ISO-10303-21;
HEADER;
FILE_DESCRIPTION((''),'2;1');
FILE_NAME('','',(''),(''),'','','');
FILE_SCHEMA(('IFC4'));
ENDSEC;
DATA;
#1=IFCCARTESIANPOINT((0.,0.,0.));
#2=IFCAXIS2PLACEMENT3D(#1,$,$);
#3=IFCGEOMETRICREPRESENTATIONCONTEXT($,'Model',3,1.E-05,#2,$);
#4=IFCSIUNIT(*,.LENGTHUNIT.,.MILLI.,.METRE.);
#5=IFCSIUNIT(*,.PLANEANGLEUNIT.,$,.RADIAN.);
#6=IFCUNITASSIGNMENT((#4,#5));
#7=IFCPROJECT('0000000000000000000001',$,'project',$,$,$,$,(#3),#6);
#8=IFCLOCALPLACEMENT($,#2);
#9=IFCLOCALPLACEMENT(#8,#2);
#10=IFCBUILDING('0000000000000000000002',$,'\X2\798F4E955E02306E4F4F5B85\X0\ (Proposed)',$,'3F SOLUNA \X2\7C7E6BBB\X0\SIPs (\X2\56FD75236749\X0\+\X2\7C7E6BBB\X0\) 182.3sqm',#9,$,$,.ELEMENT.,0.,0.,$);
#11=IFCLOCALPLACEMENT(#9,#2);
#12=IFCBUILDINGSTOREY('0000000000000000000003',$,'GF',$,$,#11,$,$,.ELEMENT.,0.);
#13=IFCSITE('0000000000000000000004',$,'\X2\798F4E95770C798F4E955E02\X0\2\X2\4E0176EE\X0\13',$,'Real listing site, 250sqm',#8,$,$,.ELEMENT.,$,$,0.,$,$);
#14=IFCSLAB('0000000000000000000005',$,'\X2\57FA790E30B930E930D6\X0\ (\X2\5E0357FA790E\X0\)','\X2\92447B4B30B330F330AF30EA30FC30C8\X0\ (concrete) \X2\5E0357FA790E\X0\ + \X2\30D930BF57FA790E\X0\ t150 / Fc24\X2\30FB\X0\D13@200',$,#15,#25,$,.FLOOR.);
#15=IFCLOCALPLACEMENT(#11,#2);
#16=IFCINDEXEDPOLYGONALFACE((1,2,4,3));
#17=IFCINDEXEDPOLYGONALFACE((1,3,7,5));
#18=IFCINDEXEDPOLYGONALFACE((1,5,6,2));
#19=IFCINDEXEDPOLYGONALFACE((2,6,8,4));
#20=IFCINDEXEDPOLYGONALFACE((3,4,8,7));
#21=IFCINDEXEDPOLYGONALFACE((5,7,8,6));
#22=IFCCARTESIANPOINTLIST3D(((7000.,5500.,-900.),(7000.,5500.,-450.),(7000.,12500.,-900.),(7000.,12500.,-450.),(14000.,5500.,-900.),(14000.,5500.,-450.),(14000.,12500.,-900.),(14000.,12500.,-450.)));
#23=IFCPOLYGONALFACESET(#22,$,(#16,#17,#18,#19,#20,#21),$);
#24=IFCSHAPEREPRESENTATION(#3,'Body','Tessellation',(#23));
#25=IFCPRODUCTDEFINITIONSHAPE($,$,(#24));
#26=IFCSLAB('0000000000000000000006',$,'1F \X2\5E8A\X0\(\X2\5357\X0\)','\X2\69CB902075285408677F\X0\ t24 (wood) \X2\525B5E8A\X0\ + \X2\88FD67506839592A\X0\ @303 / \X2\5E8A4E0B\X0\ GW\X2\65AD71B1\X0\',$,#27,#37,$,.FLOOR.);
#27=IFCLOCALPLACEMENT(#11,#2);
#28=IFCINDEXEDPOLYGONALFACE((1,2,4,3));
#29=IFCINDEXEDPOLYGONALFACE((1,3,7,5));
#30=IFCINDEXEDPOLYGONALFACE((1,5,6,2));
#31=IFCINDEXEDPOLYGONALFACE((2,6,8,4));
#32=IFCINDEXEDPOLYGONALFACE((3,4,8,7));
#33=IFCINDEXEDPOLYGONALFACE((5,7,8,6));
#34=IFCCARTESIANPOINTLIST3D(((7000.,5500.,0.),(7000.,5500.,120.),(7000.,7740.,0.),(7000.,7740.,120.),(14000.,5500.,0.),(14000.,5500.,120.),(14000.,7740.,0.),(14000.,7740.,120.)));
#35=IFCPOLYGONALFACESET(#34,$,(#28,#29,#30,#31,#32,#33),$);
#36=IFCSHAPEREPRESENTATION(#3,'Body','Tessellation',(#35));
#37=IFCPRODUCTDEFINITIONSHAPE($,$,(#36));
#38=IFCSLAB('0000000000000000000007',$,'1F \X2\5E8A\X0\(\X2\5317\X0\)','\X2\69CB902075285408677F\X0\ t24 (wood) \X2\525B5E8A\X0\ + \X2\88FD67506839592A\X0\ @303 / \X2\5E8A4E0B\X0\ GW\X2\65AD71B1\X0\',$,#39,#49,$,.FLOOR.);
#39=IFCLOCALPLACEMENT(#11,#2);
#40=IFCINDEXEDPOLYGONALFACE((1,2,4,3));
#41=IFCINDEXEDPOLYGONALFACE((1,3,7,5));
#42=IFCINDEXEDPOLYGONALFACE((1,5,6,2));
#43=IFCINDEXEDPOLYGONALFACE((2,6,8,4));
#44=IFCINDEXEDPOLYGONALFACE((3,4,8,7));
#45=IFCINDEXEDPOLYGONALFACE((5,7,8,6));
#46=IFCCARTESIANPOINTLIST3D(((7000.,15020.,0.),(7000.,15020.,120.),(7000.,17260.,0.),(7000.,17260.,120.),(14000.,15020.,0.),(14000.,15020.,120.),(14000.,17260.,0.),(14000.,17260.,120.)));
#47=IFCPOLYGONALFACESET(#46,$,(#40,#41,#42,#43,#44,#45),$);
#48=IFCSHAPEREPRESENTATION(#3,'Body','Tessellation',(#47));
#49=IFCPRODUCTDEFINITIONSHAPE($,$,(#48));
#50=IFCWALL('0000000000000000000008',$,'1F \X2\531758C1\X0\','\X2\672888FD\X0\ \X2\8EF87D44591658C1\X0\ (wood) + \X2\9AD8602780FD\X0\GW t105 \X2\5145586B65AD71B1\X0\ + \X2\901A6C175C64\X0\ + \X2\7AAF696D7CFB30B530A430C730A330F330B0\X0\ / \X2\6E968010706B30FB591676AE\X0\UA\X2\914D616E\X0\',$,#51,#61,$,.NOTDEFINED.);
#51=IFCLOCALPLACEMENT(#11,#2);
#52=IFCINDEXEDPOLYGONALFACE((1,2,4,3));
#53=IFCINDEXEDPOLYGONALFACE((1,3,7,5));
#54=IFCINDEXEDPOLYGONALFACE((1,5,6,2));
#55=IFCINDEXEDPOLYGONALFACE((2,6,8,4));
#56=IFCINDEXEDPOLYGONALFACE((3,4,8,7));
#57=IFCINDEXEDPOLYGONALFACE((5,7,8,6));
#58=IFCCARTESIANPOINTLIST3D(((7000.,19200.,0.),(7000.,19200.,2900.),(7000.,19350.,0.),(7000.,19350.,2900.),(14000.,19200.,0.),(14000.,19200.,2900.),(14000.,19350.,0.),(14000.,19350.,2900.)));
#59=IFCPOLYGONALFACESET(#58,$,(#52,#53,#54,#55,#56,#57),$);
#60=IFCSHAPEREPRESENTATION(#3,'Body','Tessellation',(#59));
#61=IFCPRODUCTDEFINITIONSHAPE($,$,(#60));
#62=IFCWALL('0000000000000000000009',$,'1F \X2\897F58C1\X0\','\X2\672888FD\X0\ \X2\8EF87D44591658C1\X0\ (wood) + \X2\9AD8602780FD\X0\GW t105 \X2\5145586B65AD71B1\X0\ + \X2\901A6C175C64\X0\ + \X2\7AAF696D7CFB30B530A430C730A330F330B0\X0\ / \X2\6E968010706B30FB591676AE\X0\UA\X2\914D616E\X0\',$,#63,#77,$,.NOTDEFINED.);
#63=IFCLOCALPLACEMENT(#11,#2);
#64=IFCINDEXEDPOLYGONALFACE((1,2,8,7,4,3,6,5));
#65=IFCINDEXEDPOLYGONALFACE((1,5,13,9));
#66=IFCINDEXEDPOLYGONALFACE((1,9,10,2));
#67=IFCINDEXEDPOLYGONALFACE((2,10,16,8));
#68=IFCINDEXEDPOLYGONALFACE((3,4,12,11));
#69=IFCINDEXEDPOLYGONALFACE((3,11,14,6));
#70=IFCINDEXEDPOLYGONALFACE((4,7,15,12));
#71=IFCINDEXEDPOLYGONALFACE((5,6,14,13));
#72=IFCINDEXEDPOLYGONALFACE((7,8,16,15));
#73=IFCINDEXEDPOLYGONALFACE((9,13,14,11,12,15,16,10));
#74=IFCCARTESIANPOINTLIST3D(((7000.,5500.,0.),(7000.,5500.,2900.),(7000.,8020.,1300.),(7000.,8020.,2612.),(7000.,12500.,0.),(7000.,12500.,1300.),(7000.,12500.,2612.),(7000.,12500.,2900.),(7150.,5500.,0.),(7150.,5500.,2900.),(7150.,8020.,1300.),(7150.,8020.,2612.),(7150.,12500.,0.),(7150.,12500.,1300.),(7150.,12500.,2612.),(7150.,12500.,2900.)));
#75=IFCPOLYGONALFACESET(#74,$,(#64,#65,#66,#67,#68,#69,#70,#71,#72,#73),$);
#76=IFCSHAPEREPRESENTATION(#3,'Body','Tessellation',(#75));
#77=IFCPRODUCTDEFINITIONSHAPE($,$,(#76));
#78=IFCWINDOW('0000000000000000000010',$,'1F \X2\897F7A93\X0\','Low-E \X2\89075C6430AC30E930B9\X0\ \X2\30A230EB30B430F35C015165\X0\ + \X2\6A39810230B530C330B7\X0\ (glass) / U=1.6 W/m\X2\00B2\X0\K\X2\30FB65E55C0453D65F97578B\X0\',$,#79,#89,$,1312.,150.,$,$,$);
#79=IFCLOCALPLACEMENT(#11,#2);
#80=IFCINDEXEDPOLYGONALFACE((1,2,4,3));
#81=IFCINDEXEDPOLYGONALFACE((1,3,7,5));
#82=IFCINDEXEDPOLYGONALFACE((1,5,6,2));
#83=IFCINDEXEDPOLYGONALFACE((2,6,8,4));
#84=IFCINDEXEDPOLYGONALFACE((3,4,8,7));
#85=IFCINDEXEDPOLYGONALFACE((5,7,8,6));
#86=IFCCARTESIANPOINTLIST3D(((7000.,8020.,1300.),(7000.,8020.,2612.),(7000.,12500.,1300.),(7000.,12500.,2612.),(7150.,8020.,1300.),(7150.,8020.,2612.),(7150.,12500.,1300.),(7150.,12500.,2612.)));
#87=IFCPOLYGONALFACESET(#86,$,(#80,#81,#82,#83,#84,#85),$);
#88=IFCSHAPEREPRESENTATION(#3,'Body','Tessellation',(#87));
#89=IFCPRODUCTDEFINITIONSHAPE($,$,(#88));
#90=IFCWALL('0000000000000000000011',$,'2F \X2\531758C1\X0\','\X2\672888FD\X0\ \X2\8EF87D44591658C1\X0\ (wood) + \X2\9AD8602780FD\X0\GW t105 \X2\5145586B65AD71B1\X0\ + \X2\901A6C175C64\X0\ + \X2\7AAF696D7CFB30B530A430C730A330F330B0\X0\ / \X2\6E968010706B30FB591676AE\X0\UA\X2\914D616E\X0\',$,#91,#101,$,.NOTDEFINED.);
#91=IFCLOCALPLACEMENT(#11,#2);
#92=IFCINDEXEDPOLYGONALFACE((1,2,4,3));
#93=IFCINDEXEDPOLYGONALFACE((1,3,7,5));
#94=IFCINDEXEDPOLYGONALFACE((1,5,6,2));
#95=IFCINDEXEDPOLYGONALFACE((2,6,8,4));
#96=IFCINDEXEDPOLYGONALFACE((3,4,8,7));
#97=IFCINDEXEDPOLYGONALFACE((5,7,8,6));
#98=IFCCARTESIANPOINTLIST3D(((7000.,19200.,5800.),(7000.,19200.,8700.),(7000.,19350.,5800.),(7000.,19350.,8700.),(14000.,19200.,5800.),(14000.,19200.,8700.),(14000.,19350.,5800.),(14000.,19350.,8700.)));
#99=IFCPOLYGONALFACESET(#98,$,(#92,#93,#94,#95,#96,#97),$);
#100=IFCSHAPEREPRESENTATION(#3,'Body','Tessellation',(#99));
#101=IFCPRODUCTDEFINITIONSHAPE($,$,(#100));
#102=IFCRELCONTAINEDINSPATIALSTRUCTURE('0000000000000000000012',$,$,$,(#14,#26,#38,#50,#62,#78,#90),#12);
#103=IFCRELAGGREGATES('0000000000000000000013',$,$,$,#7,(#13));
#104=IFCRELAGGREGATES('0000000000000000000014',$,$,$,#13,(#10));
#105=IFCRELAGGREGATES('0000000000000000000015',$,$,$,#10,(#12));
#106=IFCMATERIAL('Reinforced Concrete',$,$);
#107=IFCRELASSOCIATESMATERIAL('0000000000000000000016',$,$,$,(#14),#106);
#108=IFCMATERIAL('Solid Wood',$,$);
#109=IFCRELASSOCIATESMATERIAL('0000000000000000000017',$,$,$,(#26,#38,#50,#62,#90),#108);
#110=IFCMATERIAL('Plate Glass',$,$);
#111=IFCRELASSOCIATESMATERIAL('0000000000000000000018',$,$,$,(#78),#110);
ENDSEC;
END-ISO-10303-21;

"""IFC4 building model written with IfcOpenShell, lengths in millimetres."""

from ifc_helpers import new_model, si_unit, frame, frame_2d, origin, place, context, project, spatial, rectangle, extrude, material, element, fill, save


model = new_model("IFC4")

# Units and contexts
model_context = context("Model", 3, precision=1e-05, world=origin())
ifc_project = project(units=[si_unit("LENGTHUNIT", "METRE", prefix="MILLI"), si_unit("PLANEANGLEUNIT", "RADIAN")], contexts=[model_context])

# Site, building, storey
site_placement = place(None, origin())
site = spatial("IfcSite", under=ifc_project, at=site_placement, Name="福井県福井市2丁目13", ObjectType="Real listing site, 250sqm", CompositionType="ELEMENT", RefElevation=0.0)
building_placement = place(site_placement, origin())
building = spatial("IfcBuilding", under=site, at=building_placement, Name="福井市の住宅 (Proposed)", ObjectType="3F SOLUNA 籾殻SIPs (国産杉+籾殻) 182.3sqm", CompositionType="ELEMENT", ElevationOfRefHeight=0.0, ElevationOfTerrain=0.0)
storey_placement = place(building_placement, origin())
storey = spatial("IfcBuildingStorey", under=building, at=storey_placement, Name="GF", CompositionType="ELEMENT", Elevation=0.0)

# Slabs
ifc_material_1 = material(Name="Reinforced Concrete")
slab_1_placement = place(storey_placement, frame((3500.0, 2750.0, -450.0)))
element("IfcSlab", 1, at=slab_1_placement, inside=storey, material=ifc_material_1, Name="基礎スラブ (布基礎)", Description="鉄筋コンクリート (concrete) 布基礎 + ベタ基礎 t150 / Fc24・D13@200", PredefinedType="FLOOR", context=model_context, shape_type="SweptSolid", body=[
    extrude(rectangle(XDim=7000.0, YDim=7000.0, at=frame_2d((3500.0, 3500.0))), frame((3500.0, 2750.0, -450.0)), (0.0, 0.0, 1.0), 450.0),
])
ifc_material_2 = material(Name="Solid Wood")
slab_2_placement = place(storey_placement, frame((3500.0, 2750.0, 0.0)))
element("IfcSlab", 2, at=slab_2_placement, inside=storey, material=ifc_material_2, Name="1F 床(南)", Description="構造用合板 t24 (wood) 剛床 + 製材根太 @303 / 床下 GW断熱", PredefinedType="FLOOR", context=model_context, shape_type="SweptSolid", body=[
    extrude(rectangle(XDim=7000.0, YDim=2240.0, at=frame_2d((3500.0, 1120.0))), frame((3500.0, 2750.0, 0.0)), (0.0, 0.0, 1.0), 120.0),
])
slab_3_placement = place(storey_placement, frame((3500.0, 7510.0, 0.0)))
element("IfcSlab", 3, at=slab_3_placement, inside=storey, material=ifc_material_2, Name="1F 床(北)", Description="構造用合板 t24 (wood) 剛床 + 製材根太 @303 / 床下 GW断熱", PredefinedType="FLOOR", context=model_context, shape_type="SweptSolid", body=[
    extrude(rectangle(XDim=7000.0, YDim=2240.0, at=frame_2d((3500.0, 1120.0))), frame((3500.0, 7510.0, 0.0)), (0.0, 0.0, 1.0), 120.0),
])

# Shared definitions
ifc_material_3 = material(Name="Plate Glass")

# Wall
wall_1_placement = place(storey_placement, frame((3500.0, 9600.0, 0.0)))
element("IfcWall", 4, at=wall_1_placement, inside=storey, material=ifc_material_2, Name="1F 北壁", Description="木製 軸組外壁 (wood) + 高性能GW t105 充填断熱 + 通気層 + 窯業系サイディング / 準耐火・外皮UA配慮", PredefinedType="NOTDEFINED", context=model_context, shape_type="SweptSolid", body=[
    extrude(rectangle(XDim=7000.0, YDim=150.0, at=frame_2d((3500.0, 75.0))), frame((3500.0, 9600.0, 0.0)), (0.0, 0.0, 1.0), 2900.0),
])

# Wall, opening, window
wall_2_placement = place(storey_placement, frame((3500.0, 2750.0, 0.0)))
wall_2 = element("IfcWall", 5, at=wall_2_placement, inside=storey, material=ifc_material_2, Name="1F 西壁", Description="木製 軸組外壁 (wood) + 高性能GW t105 充填断熱 + 通気層 + 窯業系サイディング / 準耐火・外皮UA配慮", PredefinedType="NOTDEFINED", context=model_context, shape_type="SweptSolid", body=[
    extrude(rectangle(XDim=150.0, YDim=7000.0, at=frame_2d((75.0, 3500.0))), frame((3500.0, 2750.0, 0.0)), (0.0, 0.0, 1.0), 2900.0),
])
opening_1_placement = place(storey_placement, frame((3500.0, 4010.0, 650.0)))
opening_1 = element("IfcOpeningElement", 6, at=opening_1_placement, cuts=wall_2, PredefinedType="NOTDEFINED", context=model_context, shape_type="SweptSolid", body=[
    extrude(rectangle(XDim=150.0, YDim=4480.0, at=frame_2d((75.0, 2240.0))), frame((3500.0, 4010.0, 650.0)), (0.0, 0.0, 1.0), 1312.0),
])
window_1_placement = place(storey_placement, frame((3500.0, 4010.0, 650.0)))
window_1 = element("IfcWindow", 7, at=window_1_placement, inside=storey, material=ifc_material_3, Name="1F 西窓", Description="Low-E 複層ガラス アルゴン封入 + 樹脂サッシ (glass) / U=1.6 W/m²K・日射取得型", OverallHeight=1312.0, OverallWidth=150.0, context=model_context, shape_type="SweptSolid", body=[
    extrude(rectangle(XDim=150.0, YDim=4480.0, at=frame_2d((75.0, 2240.0))), frame((3500.0, 4010.0, 650.0)), (0.0, 0.0, 1.0), 1312.0),
])
fill(opening_1, window_1)

# Wall
wall_3_placement = place(storey_placement, frame((3500.0, 9600.0, 2900.0)))
element("IfcWall", 8, at=wall_3_placement, inside=storey, material=ifc_material_2, Name="2F 北壁", Description="木製 軸組外壁 (wood) + 高性能GW t105 充填断熱 + 通気層 + 窯業系サイディング / 準耐火・外皮UA配慮", PredefinedType="NOTDEFINED", context=model_context, shape_type="SweptSolid", body=[
    extrude(rectangle(XDim=7000.0, YDim=150.0, at=frame_2d((3500.0, 75.0))), frame((3500.0, 9600.0, 2900.0)), (0.0, 0.0, 1.0), 2900.0),
])

save(model, "model.ifc")
